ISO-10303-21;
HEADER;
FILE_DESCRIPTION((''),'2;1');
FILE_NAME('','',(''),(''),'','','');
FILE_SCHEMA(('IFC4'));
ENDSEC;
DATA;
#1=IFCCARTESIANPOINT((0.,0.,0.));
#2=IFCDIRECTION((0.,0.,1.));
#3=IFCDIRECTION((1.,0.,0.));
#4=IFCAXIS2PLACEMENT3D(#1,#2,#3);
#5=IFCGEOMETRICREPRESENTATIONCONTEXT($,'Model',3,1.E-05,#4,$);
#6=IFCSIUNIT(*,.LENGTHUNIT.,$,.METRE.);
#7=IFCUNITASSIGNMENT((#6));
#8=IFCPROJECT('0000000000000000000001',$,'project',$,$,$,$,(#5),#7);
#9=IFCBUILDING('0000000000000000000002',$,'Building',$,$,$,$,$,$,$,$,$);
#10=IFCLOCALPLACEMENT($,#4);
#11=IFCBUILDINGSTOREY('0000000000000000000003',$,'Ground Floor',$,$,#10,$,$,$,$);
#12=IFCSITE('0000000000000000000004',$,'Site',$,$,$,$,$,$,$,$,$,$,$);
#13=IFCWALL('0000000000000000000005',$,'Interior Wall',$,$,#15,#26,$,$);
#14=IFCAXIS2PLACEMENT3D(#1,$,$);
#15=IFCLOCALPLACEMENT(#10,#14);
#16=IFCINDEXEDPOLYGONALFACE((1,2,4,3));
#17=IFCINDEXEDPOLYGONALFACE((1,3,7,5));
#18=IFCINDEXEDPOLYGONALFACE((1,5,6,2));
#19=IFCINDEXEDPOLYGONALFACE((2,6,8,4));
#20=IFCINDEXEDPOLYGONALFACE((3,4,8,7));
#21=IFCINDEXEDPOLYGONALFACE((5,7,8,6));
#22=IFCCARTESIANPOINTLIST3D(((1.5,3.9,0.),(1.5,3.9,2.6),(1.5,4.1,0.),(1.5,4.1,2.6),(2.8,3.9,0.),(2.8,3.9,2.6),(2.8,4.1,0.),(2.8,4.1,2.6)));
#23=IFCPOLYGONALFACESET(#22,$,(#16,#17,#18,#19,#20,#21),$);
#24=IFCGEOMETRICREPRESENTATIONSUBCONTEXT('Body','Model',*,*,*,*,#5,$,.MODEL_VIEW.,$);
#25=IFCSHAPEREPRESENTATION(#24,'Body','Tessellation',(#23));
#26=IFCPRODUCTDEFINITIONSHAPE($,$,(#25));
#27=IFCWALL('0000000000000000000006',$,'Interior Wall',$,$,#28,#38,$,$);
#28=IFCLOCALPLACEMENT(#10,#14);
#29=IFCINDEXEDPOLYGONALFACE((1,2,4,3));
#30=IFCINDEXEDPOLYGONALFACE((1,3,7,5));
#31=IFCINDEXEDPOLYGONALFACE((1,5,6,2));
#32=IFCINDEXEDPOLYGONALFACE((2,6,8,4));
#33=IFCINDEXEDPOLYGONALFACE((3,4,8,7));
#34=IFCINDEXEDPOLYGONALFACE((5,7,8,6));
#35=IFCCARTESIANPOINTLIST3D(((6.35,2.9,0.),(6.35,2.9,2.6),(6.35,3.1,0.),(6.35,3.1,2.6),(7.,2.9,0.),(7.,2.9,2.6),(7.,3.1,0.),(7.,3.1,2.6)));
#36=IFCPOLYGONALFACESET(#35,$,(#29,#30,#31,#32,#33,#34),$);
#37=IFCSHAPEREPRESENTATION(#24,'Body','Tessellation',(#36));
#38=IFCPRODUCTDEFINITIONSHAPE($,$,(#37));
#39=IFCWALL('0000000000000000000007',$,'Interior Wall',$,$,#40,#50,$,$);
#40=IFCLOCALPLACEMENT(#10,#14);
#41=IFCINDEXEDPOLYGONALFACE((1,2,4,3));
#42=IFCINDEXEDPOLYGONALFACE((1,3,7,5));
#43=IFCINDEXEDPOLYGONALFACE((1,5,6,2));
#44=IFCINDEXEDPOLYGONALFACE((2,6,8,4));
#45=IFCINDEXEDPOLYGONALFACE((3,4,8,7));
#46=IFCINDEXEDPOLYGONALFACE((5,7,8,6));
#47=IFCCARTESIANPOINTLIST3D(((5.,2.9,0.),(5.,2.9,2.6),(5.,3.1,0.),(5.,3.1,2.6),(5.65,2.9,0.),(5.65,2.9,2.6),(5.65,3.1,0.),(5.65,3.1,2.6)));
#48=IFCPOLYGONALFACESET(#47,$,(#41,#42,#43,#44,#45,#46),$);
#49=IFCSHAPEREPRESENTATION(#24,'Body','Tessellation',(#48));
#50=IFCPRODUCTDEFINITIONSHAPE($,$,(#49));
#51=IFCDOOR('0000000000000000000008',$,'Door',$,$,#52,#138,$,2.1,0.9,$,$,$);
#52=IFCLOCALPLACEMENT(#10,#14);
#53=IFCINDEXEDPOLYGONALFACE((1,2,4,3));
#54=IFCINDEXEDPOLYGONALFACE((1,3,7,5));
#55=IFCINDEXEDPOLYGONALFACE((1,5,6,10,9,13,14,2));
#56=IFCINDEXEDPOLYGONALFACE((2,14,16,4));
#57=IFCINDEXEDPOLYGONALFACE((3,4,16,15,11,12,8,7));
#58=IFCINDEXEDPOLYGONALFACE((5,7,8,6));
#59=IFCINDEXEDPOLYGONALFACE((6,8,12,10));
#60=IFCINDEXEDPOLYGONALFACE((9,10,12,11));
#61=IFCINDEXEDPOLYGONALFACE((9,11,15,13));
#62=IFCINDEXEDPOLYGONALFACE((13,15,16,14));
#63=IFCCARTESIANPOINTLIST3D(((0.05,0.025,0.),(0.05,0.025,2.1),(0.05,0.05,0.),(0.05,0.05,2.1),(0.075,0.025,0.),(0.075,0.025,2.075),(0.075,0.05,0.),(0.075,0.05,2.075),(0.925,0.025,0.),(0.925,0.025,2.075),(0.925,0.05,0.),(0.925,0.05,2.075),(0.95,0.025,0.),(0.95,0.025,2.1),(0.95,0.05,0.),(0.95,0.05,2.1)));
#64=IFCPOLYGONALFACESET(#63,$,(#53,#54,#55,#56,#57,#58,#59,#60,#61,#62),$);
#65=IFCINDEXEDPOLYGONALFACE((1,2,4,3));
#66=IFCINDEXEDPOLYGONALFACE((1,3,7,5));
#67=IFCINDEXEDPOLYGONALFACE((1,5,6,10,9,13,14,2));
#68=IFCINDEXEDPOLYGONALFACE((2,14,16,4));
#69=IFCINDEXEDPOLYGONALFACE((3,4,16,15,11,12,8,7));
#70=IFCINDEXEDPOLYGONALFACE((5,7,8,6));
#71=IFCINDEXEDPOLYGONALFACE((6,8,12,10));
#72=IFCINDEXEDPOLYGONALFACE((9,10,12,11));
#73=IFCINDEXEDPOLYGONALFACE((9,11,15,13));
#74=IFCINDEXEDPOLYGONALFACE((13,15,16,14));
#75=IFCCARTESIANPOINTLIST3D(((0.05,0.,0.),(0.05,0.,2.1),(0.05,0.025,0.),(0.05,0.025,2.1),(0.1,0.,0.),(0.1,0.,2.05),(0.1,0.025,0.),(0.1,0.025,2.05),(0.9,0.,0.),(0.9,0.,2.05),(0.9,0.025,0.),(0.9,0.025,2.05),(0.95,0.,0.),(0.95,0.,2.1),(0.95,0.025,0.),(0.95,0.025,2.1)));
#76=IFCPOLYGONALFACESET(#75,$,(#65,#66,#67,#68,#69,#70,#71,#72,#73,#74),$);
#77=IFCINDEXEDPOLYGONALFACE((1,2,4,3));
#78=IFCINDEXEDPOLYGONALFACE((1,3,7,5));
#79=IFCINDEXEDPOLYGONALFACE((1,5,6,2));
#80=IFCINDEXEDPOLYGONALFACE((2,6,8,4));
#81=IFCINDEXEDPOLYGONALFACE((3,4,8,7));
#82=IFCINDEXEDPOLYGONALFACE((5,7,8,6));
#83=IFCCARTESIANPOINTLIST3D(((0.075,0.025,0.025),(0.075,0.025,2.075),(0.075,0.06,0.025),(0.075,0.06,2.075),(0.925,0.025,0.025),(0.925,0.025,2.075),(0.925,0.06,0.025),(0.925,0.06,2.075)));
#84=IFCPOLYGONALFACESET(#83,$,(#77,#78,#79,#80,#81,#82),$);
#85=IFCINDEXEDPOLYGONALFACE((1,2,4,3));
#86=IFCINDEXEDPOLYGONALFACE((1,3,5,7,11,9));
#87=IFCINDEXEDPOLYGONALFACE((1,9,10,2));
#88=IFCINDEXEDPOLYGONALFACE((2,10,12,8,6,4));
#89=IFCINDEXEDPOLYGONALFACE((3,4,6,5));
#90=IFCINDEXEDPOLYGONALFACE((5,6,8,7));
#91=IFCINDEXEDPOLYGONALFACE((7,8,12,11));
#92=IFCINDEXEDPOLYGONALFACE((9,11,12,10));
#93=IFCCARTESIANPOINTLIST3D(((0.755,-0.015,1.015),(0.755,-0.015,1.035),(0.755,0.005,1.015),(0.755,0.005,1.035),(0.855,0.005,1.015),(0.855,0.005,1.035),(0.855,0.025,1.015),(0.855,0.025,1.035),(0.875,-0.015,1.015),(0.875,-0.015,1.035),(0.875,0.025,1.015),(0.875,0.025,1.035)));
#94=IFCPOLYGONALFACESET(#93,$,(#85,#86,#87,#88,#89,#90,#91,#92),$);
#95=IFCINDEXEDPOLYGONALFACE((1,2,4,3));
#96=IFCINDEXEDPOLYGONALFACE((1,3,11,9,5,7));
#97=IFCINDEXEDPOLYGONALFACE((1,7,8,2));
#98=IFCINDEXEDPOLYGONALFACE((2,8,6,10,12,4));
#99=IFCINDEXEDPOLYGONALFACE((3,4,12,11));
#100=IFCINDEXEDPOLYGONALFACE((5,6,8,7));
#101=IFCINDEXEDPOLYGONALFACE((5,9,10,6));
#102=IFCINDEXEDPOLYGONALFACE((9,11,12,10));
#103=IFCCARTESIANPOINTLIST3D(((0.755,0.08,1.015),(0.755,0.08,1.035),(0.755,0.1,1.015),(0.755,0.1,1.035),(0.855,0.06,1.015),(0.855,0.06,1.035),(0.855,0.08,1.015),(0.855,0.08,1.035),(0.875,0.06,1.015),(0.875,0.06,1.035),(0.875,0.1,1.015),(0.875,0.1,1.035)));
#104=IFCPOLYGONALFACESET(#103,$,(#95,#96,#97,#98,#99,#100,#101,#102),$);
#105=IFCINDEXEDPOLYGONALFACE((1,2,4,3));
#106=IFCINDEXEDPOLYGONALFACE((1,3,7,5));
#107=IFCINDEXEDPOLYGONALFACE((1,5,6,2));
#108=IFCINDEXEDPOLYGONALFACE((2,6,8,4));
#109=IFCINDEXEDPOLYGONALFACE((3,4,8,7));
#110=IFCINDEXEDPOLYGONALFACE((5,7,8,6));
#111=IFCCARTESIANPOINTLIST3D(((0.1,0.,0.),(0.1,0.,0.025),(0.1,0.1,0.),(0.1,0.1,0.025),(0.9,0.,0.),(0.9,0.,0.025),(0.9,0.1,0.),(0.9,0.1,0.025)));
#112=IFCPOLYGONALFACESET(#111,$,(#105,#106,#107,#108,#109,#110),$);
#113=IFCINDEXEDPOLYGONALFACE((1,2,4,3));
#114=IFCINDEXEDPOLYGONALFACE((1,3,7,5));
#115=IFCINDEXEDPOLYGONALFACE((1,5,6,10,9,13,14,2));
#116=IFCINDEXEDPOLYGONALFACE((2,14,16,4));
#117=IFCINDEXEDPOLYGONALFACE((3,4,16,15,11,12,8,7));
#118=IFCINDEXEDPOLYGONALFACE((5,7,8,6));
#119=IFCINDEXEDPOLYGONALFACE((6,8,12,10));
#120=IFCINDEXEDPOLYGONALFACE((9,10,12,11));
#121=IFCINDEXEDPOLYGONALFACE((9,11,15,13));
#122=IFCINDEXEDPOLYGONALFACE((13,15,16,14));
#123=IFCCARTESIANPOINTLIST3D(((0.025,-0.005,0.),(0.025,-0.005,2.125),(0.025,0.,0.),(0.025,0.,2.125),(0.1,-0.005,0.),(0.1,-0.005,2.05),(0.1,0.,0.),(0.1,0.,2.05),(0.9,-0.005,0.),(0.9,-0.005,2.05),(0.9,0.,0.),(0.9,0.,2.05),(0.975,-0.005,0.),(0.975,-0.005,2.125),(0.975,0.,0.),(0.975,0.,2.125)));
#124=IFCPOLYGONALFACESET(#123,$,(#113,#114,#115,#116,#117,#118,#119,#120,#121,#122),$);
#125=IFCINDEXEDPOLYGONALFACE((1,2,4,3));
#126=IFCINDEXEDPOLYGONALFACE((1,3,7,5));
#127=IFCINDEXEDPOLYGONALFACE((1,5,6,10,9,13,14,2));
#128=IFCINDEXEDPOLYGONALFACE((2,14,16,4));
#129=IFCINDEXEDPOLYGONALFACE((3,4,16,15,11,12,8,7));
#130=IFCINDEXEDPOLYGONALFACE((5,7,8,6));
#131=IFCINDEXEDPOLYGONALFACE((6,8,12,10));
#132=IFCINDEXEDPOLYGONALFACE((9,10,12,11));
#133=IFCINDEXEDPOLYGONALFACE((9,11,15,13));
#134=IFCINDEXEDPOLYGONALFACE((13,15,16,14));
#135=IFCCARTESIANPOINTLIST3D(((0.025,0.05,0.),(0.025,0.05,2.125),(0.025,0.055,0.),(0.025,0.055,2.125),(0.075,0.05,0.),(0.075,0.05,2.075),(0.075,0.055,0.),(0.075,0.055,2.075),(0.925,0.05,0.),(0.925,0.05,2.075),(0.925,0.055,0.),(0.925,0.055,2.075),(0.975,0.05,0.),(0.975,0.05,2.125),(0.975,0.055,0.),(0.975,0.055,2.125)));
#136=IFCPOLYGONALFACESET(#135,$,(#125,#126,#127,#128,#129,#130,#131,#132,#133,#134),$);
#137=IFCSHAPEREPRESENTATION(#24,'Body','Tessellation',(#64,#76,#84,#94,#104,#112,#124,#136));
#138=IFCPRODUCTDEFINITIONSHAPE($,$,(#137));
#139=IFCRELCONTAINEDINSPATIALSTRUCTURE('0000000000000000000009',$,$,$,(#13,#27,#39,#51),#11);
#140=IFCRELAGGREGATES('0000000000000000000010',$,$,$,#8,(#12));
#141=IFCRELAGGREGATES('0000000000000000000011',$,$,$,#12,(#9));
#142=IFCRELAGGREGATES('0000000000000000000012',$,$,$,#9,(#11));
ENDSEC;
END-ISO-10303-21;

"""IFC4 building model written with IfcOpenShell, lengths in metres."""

from ifc_helpers import new_model, si_unit, frame, origin_with_axes, place, context, subcontext, project, spatial, line, indexed_curve, outline, extrude, element, save


model = new_model("IFC4")

# Units and contexts
model_context = context("Model", 3, precision=1e-05, world=origin_with_axes())
body_context = subcontext(model_context, "Body", "Model", "MODEL_VIEW")
ifc_project = project(units=[si_unit("LENGTHUNIT", "METRE")], contexts=[model_context])

# Site, building, storey
site = spatial("IfcSite", under=ifc_project, Name="Site")
building = spatial("IfcBuilding", under=site, Name="Building")
storey_placement = place(None, origin_with_axes())
storey = spatial("IfcBuildingStorey", under=building, at=storey_placement, Name="Ground Floor")

# Walls
for number, where, z_axis, x_axis, name in (
    (1, (2.8, 4.0, 0.0), (0.0, 0.0, 1.0), (-1.0, 0.0, 0.0), "Interior Wall"),
):
    element("IfcWall", number, at=place(storey_placement, frame(where, z_axis=z_axis, x_axis=x_axis)), inside=storey, Name=name, context=body_context, shape_type="SweptSolid", body=[
        extrude(outline(indexed_curve([(0.0, 0.0), (0.0, 0.2), (1.3, 0.2), (1.3, 0.0), (0.0, 0.0)], self_intersect=False)), frame((0.0, -0.1, 0.0), z_axis=(0.0, 0.0, 1.0), x_axis=(1.0, 0.0, 0.0)), (0.0, 0.0, 1.0), 2.6),
    ])
for number, where, z_axis, x_axis, name in (
    (2, (7.0, 3.0, 0.0), (0.0, 0.0, 1.0), (-1.0, 0.0, 0.0), "Interior Wall"),
    (3, (5.65, 3.0, 0.0), (0.0, 0.0, 1.0), (-1.0, 0.0, 0.0), "Interior Wall"),
):
    element("IfcWall", number, at=place(storey_placement, frame(where, z_axis=z_axis, x_axis=x_axis)), inside=storey, Name=name, context=body_context, shape_type="SweptSolid", body=[
        extrude(outline(indexed_curve([(0.0, 0.0), (0.0, 0.2), (0.65, 0.2), (0.65, 0.0), (0.0, 0.0)], self_intersect=False)), frame((0.0, -0.1, 0.0), z_axis=(0.0, 0.0, 1.0), x_axis=(1.0, 0.0, 0.0)), (0.0, 0.0, 1.0), 2.6),
    ])

# Door
door_1_placement = place(storey_placement, frame((0.05, 0.0, 0.0), z_axis=(0.0, 0.0, 1.0), x_axis=(1.0, 0.0, 0.0)))
element("IfcDoor", 4, at=door_1_placement, inside=storey, Name="Door", OverallHeight=2.1, OverallWidth=0.9, context=body_context, shape_type="SweptSolid", body=[
    extrude(outline(indexed_curve([(0.0, 0.0), (0.0, 2.1), (0.9, 2.1), (0.9, 0.0), (0.875, 0.0), (0.875, 2.075), (0.025, 2.075), (0.025, 0.0)], segments=[line(1, 2, 3, 4, 5, 6, 7, 8, 1)])), frame((0.0, 0.025, 0.0), z_axis=(0.0, -1.0, 0.0), x_axis=(1.0, 0.0, 0.0)), (0.0, 0.0, -1.0), 0.025),
    extrude(outline(indexed_curve([(0.0, 0.0), (0.0, 2.1), (0.9, 2.1), (0.9, 0.0), (0.85, 0.0), (0.85, 2.05), (0.05, 2.05), (0.05, 0.0)], segments=[line(1, 2, 3, 4, 5, 6, 7, 8, 1)])), frame((0.0, 0.0, 0.0), z_axis=(0.0, -1.0, 0.0), x_axis=(1.0, 0.0, 0.0)), (0.0, 0.0, -1.0), 0.025),
    extrude(outline(indexed_curve([(0.0, 0.0), (0.85, 0.0), (0.85, 0.035), (0.0, 0.035)], segments=[line(1, 2, 3, 4, 1)])), frame((0.025, 0.025, 0.025), z_axis=(0.0, 0.0, 1.0), x_axis=(1.0, 0.0, 0.0)), (0.0, 0.0, 1.0), 2.05),
    extrude(outline(indexed_curve([(0.0, 0.0), (0.0, -0.04), (-0.12, -0.04), (-0.12, -0.02), (-0.02, -0.02), (-0.02, 0.0)], segments=[line(1, 2, 3, 4, 5, 6, 1)])), frame((0.825, 0.025, 1.015), z_axis=(0.0, 0.0, 1.0), x_axis=(1.0, 0.0, 0.0)), (0.0, 0.0, 1.0), 0.02),
    extrude(outline(indexed_curve([(0.0, 0.0), (0.0, 0.04), (-0.12, 0.04), (-0.12, 0.02), (-0.02, 0.02), (-0.02, 0.0)], segments=[line(1, 2, 3, 4, 5, 6, 1)])), frame((0.825, 0.06, 1.015), z_axis=(0.0, 0.0, 1.0), x_axis=(1.0, 0.0, 0.0)), (0.0, 0.0, 1.0), 0.02),
    extrude(outline(indexed_curve([(0.0, 0.0), (0.8, 0.0), (0.8, 0.1), (0.0, 0.1)], segments=[line(1, 2, 3, 4, 1)])), frame((0.05, 0.0, 0.0), z_axis=(0.0, 0.0, 1.0), x_axis=(1.0, 0.0, 0.0)), (0.0, 0.0, 1.0), 0.025),
    extrude(outline(indexed_curve([(0.0, 0.0), (0.0, 2.125), (0.95, 2.125), (0.95, 0.0), (0.875, 0.0), (0.875, 2.05), (0.075, 2.05), (0.075, 0.0)], segments=[line(1, 2, 3, 4, 5, 6, 7, 8, 1)])), frame((-0.025, -0.005, 0.0), z_axis=(0.0, -1.0, 0.0), x_axis=(1.0, 0.0, 0.0)), (0.0, 0.0, -1.0), 0.005),
    extrude(outline(indexed_curve([(0.0, 0.0), (0.0, 2.125), (0.95, 2.125), (0.95, 0.0), (0.9, 0.0), (0.9, 2.075), (0.05, 2.075), (0.05, 0.0)], segments=[line(1, 2, 3, 4, 5, 6, 7, 8, 1)])), frame((-0.025, 0.05, 0.0), z_axis=(0.0, -1.0, 0.0), x_axis=(1.0, 0.0, 0.0)), (0.0, 0.0, -1.0), 0.005),
])

save(model, "model.ifc")
